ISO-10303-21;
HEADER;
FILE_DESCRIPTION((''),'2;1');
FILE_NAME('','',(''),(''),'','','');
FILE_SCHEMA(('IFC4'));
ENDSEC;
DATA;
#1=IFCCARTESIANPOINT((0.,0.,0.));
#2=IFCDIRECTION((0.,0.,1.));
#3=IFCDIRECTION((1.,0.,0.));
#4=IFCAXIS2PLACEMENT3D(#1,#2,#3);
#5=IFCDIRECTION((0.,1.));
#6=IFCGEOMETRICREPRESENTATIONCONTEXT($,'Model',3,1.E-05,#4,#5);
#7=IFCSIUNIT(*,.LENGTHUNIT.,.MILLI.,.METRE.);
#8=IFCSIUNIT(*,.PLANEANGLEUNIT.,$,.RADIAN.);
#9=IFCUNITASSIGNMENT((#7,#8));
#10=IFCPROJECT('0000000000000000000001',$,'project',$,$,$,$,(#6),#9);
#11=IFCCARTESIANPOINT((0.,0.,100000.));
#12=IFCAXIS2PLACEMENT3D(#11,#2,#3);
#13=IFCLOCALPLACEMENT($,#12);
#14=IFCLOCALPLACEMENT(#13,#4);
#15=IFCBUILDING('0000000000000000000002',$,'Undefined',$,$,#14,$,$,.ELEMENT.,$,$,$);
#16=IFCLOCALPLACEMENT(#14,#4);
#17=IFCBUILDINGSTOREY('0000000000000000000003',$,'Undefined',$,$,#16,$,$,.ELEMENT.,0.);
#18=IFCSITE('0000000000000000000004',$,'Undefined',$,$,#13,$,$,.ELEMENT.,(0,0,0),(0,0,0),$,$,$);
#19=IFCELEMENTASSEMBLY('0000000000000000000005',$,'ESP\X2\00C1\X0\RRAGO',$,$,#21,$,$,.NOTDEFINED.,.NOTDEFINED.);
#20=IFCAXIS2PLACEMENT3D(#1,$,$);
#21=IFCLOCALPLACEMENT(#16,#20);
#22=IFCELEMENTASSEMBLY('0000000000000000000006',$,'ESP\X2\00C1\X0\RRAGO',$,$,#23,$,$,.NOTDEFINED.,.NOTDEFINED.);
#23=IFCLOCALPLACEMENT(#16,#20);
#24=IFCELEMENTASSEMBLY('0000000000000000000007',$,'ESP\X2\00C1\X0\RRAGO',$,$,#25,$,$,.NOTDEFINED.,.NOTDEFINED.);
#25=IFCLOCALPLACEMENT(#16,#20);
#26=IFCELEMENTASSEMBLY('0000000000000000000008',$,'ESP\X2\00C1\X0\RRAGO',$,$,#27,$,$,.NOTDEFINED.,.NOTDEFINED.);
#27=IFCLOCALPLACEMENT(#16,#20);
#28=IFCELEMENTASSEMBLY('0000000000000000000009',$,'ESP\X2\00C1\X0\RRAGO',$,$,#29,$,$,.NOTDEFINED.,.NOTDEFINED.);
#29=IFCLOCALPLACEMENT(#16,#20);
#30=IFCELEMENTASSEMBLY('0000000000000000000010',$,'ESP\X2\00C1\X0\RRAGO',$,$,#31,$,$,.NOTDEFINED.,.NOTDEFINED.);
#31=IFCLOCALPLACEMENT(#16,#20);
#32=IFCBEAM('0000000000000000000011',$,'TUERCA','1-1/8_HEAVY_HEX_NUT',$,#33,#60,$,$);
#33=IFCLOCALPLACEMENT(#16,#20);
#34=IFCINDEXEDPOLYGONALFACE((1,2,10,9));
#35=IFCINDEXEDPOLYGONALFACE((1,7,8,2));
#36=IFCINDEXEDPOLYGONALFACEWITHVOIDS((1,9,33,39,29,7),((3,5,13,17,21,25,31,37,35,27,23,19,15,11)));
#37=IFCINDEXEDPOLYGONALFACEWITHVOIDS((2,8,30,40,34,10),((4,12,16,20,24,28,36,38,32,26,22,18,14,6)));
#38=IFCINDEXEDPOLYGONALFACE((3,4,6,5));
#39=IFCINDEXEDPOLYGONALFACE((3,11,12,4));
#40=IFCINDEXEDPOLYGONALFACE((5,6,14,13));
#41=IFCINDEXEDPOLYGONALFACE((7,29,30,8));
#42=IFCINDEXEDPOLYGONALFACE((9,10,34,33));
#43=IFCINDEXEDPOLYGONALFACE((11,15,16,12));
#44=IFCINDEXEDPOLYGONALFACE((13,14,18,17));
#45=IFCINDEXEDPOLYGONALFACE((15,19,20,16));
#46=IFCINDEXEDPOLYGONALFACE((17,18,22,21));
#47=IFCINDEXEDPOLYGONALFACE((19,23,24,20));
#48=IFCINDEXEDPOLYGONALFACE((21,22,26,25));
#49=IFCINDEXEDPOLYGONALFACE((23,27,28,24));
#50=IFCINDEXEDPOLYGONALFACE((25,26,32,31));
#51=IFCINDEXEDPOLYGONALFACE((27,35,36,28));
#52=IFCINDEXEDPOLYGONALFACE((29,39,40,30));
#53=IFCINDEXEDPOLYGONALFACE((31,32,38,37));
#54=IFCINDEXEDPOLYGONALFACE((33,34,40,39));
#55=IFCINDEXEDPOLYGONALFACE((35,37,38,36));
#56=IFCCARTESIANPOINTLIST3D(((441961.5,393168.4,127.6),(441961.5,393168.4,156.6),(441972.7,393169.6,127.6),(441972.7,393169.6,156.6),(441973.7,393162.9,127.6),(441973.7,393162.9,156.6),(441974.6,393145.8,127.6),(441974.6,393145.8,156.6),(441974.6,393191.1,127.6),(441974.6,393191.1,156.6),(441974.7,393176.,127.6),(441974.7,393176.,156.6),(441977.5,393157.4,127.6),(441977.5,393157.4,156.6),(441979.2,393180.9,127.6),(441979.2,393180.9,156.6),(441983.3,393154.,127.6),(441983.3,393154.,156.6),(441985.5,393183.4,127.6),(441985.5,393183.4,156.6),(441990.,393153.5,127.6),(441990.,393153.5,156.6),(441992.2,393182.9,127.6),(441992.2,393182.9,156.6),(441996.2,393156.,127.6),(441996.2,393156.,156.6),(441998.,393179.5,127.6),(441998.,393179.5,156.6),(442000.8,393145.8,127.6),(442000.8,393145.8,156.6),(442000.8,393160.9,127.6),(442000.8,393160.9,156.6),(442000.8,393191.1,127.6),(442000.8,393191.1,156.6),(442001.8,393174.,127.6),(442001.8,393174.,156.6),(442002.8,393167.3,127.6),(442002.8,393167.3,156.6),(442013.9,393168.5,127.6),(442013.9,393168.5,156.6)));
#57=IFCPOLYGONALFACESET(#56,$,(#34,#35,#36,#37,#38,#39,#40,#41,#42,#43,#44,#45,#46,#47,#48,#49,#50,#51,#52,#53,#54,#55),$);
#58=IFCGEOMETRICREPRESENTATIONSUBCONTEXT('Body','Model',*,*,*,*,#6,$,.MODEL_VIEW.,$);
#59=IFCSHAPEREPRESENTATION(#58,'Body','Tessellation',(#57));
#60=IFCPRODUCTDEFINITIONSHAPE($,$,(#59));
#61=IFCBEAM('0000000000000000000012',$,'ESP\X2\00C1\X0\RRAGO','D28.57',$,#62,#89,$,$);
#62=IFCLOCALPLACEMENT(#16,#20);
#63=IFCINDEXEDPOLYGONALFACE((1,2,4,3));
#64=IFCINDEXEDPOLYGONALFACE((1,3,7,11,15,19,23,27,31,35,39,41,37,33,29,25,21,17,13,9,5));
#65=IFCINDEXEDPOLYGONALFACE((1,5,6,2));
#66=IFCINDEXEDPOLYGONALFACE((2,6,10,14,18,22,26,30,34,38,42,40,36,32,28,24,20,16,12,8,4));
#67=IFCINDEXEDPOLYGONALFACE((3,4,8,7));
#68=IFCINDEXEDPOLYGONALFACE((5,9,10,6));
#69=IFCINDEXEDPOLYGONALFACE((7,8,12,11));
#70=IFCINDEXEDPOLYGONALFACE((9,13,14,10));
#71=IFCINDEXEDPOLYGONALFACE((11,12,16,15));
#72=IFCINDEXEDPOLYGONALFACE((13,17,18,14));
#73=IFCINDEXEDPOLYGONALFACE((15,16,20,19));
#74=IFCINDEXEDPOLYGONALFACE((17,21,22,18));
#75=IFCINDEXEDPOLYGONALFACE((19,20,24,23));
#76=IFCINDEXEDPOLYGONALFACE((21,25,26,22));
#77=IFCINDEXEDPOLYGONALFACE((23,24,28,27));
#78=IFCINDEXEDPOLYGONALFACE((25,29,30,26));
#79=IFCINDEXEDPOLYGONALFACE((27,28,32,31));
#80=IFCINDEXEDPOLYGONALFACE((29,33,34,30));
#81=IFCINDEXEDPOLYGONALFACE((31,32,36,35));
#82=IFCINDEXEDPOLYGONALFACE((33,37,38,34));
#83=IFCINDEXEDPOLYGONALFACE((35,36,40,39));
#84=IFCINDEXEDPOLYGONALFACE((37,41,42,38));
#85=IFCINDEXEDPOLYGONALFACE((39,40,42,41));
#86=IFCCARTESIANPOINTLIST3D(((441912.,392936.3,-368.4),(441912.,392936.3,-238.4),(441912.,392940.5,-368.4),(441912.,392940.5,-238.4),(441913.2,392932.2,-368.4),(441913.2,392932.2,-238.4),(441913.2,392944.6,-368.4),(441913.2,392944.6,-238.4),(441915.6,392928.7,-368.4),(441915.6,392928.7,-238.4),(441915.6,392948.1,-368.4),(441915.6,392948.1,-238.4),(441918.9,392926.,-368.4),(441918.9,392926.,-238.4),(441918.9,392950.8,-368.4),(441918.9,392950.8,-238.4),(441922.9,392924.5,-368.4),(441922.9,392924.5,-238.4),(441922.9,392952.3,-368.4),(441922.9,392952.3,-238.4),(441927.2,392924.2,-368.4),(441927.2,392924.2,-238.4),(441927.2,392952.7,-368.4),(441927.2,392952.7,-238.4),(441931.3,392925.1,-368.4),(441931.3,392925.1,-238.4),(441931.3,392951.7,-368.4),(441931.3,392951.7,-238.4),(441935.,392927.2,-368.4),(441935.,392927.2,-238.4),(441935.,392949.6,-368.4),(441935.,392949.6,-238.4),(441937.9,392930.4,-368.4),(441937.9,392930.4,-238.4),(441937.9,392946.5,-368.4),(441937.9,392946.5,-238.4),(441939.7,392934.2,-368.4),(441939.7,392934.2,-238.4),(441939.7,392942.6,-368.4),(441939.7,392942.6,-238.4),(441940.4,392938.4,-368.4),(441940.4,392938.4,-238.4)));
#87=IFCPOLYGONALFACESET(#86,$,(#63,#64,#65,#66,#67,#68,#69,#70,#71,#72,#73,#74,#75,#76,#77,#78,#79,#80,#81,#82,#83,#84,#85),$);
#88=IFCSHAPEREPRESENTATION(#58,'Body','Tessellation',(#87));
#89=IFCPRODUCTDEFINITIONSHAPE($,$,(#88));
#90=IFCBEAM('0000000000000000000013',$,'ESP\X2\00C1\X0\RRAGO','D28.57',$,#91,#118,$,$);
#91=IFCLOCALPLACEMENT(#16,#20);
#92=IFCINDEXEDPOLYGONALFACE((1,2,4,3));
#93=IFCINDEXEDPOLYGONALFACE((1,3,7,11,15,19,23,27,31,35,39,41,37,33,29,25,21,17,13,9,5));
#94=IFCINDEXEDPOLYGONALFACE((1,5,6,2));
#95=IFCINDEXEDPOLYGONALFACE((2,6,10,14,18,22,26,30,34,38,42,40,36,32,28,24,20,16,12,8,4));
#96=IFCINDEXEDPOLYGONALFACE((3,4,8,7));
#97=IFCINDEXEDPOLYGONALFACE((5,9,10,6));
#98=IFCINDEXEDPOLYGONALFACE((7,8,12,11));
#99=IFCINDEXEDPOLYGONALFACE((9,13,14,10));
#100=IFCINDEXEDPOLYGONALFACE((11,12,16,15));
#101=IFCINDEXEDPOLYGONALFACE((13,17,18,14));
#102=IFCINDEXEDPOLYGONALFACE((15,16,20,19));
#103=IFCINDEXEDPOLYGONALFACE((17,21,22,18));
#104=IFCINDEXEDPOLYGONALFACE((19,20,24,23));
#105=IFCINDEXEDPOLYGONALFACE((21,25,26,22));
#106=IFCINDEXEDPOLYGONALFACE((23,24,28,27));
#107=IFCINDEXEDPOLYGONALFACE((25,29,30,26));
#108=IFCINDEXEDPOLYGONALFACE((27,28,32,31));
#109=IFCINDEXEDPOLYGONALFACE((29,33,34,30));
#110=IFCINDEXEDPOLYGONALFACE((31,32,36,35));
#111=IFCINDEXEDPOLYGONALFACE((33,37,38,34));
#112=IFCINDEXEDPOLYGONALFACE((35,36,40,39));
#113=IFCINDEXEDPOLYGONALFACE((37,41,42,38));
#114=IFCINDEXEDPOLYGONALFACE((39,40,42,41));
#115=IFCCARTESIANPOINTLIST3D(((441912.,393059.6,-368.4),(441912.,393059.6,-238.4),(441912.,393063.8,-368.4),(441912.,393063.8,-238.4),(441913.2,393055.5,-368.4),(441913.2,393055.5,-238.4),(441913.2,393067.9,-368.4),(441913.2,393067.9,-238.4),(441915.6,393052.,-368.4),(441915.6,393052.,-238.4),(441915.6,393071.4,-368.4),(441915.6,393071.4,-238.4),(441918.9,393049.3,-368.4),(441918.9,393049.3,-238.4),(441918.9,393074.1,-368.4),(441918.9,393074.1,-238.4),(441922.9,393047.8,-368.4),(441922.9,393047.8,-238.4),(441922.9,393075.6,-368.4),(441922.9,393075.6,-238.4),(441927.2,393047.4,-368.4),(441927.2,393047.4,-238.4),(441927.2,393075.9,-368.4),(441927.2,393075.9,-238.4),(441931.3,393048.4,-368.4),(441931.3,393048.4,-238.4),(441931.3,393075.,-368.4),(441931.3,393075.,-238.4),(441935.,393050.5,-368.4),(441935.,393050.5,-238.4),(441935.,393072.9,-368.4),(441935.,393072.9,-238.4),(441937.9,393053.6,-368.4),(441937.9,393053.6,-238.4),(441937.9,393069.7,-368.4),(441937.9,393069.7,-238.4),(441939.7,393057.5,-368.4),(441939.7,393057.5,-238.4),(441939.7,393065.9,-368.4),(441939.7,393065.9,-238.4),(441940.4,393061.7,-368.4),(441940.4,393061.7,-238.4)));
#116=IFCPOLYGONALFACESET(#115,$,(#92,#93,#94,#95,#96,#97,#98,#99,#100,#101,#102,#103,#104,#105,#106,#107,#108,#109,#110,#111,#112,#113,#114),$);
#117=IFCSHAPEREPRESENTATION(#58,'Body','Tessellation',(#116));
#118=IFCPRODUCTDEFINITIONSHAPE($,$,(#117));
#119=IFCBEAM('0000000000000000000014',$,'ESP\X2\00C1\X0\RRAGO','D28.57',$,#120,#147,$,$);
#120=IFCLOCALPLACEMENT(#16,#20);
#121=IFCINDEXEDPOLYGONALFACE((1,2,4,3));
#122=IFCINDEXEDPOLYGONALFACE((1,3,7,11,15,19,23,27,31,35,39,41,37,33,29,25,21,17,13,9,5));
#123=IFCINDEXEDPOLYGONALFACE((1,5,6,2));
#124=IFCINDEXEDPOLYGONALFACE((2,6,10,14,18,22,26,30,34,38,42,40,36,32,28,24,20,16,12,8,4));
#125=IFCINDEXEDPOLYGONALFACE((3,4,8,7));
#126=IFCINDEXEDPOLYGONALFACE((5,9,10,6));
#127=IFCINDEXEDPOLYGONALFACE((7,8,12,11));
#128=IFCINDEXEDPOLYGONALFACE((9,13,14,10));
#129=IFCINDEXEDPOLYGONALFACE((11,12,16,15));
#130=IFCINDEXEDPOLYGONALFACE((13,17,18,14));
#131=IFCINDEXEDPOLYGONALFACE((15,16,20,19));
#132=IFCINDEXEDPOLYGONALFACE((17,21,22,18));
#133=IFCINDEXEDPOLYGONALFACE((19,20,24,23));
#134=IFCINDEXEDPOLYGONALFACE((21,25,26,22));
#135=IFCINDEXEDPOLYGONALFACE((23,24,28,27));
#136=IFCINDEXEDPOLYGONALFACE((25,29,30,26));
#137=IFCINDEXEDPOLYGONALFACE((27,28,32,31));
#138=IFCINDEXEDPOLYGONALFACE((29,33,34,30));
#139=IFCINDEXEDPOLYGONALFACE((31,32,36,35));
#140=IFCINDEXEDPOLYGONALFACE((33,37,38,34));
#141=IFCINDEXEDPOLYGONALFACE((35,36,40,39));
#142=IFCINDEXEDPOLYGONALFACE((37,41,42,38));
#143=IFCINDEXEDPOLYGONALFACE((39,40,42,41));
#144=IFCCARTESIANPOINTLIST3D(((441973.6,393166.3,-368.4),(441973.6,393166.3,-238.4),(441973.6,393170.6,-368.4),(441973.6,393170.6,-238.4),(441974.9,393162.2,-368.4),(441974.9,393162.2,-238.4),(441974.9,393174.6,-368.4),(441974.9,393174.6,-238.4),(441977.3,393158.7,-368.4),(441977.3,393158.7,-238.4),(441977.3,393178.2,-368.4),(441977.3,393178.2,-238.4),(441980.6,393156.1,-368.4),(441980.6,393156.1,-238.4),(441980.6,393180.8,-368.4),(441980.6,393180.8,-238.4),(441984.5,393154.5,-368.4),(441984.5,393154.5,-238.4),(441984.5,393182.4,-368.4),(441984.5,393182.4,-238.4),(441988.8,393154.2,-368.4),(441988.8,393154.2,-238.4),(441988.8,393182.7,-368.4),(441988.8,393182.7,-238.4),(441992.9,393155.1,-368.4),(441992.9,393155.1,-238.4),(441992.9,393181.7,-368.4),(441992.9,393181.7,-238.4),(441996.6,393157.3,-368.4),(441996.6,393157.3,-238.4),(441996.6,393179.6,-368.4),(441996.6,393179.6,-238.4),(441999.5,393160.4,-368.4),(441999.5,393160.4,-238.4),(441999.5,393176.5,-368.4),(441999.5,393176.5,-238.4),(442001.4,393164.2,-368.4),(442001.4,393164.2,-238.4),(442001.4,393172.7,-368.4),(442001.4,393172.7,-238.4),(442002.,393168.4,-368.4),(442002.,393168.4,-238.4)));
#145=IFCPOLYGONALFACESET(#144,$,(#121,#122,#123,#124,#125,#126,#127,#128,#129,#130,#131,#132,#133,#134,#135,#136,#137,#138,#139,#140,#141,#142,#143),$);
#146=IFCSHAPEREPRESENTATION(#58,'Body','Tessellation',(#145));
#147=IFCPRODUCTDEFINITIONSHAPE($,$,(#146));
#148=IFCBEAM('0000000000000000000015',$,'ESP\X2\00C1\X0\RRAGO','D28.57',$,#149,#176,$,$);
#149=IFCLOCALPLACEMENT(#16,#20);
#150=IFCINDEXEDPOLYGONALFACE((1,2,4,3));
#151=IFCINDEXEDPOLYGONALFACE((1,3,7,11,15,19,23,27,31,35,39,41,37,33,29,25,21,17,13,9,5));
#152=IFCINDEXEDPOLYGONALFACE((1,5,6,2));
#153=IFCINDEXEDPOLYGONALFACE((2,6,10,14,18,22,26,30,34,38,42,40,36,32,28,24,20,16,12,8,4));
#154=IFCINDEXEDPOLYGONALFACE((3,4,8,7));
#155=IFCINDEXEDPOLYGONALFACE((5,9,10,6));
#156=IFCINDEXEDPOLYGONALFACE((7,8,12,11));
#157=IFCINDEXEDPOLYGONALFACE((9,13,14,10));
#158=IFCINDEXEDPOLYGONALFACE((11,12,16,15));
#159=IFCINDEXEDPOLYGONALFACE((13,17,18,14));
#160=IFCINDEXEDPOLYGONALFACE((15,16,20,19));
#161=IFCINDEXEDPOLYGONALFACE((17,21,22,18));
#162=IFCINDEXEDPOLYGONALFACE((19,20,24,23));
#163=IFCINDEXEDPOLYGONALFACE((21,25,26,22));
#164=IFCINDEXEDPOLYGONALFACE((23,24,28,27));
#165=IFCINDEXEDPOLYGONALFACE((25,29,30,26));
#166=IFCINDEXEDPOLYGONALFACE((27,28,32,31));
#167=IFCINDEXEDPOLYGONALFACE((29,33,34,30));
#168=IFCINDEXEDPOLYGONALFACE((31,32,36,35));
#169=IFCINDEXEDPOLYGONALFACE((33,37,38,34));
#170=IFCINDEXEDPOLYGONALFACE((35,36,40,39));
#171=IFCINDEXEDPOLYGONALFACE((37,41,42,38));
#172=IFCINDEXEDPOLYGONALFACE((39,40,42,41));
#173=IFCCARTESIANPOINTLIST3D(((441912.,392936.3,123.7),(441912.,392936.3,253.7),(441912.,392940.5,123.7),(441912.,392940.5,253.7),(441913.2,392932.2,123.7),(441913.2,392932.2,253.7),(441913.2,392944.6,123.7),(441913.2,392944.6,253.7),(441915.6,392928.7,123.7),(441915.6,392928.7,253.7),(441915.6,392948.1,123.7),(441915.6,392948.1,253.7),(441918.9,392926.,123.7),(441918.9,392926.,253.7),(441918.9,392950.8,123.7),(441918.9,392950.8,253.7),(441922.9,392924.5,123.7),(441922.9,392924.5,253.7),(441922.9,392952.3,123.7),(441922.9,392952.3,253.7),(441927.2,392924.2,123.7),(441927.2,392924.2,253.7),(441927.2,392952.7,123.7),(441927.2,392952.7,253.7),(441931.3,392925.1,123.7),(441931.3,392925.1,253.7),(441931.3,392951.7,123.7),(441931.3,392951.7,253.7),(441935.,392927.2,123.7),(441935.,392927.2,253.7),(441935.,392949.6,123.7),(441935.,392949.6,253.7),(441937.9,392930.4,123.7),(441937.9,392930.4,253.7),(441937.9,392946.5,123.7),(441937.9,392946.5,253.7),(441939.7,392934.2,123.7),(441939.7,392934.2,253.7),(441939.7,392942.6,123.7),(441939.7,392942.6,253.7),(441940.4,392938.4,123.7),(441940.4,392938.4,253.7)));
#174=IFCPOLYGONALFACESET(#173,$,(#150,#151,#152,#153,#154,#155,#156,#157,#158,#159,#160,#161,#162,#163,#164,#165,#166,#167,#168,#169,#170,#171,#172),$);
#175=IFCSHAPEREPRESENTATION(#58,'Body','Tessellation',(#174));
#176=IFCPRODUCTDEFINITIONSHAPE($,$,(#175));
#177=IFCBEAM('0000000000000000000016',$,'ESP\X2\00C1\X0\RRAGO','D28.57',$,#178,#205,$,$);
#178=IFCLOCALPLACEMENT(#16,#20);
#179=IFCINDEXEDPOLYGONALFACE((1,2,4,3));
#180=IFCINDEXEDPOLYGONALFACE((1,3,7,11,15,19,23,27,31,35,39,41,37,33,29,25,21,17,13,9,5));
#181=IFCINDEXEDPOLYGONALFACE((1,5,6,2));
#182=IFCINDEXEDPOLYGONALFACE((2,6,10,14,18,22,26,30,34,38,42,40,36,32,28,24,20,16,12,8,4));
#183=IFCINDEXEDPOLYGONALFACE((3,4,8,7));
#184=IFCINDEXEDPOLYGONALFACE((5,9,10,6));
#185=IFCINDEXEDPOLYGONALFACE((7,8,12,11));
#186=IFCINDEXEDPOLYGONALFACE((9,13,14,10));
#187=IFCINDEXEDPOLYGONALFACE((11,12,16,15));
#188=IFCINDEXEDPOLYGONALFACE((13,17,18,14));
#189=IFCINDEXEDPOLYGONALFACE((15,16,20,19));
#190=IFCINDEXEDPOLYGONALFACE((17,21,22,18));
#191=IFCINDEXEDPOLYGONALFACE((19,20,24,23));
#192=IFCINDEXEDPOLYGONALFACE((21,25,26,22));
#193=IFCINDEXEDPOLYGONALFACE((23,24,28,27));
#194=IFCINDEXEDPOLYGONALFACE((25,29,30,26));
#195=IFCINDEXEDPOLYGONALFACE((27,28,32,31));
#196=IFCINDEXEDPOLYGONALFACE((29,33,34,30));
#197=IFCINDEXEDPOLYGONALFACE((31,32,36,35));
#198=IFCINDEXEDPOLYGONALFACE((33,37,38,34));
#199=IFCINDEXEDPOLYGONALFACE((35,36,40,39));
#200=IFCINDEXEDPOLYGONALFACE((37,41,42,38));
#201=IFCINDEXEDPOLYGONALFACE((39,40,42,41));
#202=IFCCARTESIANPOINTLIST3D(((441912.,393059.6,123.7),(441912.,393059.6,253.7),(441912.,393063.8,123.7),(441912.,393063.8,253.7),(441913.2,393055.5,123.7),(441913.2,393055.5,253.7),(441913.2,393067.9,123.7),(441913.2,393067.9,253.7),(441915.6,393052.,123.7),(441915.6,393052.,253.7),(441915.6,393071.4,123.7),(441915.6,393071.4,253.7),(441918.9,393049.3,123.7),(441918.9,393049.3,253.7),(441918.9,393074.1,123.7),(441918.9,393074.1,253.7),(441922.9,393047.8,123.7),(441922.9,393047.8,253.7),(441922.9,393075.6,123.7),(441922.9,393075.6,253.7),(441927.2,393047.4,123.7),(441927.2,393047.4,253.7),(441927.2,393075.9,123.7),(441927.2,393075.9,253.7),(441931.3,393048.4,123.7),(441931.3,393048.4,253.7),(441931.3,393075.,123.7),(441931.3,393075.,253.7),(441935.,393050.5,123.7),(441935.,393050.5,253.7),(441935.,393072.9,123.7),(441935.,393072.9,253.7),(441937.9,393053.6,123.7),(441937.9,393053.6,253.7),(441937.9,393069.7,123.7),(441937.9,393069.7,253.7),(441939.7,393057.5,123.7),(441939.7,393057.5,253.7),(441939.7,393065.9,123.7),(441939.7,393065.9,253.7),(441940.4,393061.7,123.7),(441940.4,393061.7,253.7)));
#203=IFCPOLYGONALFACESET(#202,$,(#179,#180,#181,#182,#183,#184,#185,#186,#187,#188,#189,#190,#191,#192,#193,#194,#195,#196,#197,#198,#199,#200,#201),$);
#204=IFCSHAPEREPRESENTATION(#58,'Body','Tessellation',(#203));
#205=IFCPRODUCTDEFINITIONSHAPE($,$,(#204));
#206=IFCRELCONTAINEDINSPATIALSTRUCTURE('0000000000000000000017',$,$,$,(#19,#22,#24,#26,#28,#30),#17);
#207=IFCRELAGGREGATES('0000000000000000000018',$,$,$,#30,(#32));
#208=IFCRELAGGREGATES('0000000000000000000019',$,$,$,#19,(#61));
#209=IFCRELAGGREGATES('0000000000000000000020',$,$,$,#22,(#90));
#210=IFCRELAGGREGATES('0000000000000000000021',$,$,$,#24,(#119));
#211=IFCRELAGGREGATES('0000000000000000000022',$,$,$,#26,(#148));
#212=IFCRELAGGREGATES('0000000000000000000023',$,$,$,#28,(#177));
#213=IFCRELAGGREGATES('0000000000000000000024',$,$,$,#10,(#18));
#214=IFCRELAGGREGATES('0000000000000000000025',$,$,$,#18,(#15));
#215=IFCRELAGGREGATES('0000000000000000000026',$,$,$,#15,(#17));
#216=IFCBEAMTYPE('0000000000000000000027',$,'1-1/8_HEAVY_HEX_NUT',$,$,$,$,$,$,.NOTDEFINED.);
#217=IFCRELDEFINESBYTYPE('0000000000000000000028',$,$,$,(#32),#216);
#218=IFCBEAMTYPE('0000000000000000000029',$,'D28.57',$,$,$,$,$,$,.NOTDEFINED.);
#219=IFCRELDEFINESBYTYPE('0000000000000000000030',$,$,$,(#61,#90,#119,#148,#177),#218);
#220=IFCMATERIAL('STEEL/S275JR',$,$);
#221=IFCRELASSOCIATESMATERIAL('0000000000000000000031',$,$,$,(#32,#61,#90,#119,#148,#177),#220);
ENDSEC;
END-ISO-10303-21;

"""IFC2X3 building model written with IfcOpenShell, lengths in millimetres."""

from ifc_helpers import new_model, si_unit, direction, frame, origin_with_axes, origin_2d_with_axis, place, context, subcontext, project, spatial, polyline, circle, outline, extrude, material, type_object, element, aggregate, save


model = new_model("IFC2X3")

# Units and contexts
model_context = context("Model", 3, precision=1e-05, world=origin_with_axes(), true_north=direction((0.0, 1.0)))
body_context = subcontext(model_context, "Body", "Model", "MODEL_VIEW")
ifc_project = project(units=[si_unit("LENGTHUNIT", "METRE", prefix="MILLI"), si_unit("PLANEANGLEUNIT", "RADIAN")], contexts=[model_context])

# Site, building, storey
site_placement = place(None, frame((0.0, 0.0, 100000.0), z_axis=(0.0, 0.0, 1.0), x_axis=(1.0, 0.0, 0.0)))
site = spatial("IfcSite", under=ifc_project, at=site_placement, Name="Undefined", CompositionType="ELEMENT", RefLatitude=(0, 0, 0), RefLongitude=(0, 0, 0))
building_placement = place(site_placement, origin_with_axes())
building = spatial("IfcBuilding", under=site, at=building_placement, Name="Undefined", CompositionType="ELEMENT")
storey_placement = place(building_placement, origin_with_axes())
storey = spatial("IfcBuildingStorey", under=building, at=storey_placement, Name="Undefined", CompositionType="ELEMENT", Elevation=0.0)

# Element assemblies
assembly_1_placement = place(storey_placement, origin_with_axes())
assembly_1 = element("IfcElementAssembly", 1, at=assembly_1_placement, inside=storey, Name="ESPÁRRAGO", AssemblyPlace="NOTDEFINED", PredefinedType="NOTDEFINED")
ifc_material_1 = material(Name="STEEL/S275JR")
beam_type_1 = type_object("IfcBeamType", Name="1-1/8_HEAVY_HEX_NUT", PredefinedType="NOTDEFINED")
assembly_2_placement = place(storey_placement, origin_with_axes())
assembly_2 = element("IfcElementAssembly", 2, at=assembly_2_placement, inside=storey, Name="ESPÁRRAGO", AssemblyPlace="NOTDEFINED", PredefinedType="NOTDEFINED")
assembly_3_placement = place(storey_placement, origin_with_axes())
assembly_3 = element("IfcElementAssembly", 3, at=assembly_3_placement, inside=storey, Name="ESPÁRRAGO", AssemblyPlace="NOTDEFINED", PredefinedType="NOTDEFINED")

# Element assemblies
assembly_4_placement = place(storey_placement, origin_with_axes())
assembly_4 = element("IfcElementAssembly", 4, at=assembly_4_placement, inside=storey, Name="ESPÁRRAGO", AssemblyPlace="NOTDEFINED", PredefinedType="NOTDEFINED")
assembly_5_placement = place(storey_placement, origin_with_axes())
assembly_5 = element("IfcElementAssembly", 5, at=assembly_5_placement, inside=storey, Name="ESPÁRRAGO", AssemblyPlace="NOTDEFINED", PredefinedType="NOTDEFINED")

# Element assembly, beam
assembly_6_placement = place(storey_placement, origin_with_axes())
assembly_6 = element("IfcElementAssembly", 6, at=assembly_6_placement, inside=storey, Name="ESPÁRRAGO", AssemblyPlace="NOTDEFINED", PredefinedType="NOTDEFINED")
beam_1_placement = place(assembly_6_placement, frame((441987.7, 393168.4, 156.6), z_axis=(0.866025, -0.5, 0.0), x_axis=(0.0, 0.0, -1.0)))
beam_1 = element("IfcBeam", 7, at=beam_1_placement, type_object=beam_type_1, material=ifc_material_1, Name="TUERCA", Description="1-1/8_HEAVY_HEX_NUT", context=body_context, shape_type="SweptSolid", body=[
    extrude(outline(polyline([(-13.1, -22.7), (-26.2, 0.0), (-13.1, 22.7), (13.1, 22.7), (26.2, 0.0), (13.1, -22.7), (-13.1, -22.7)]), holes=[polyline([(6.5, 13.6), (0.0, 15.1), (-6.5, 13.6), (-11.8, 9.4), (-14.7, 3.4), (-14.7, -3.4), (-11.8, -9.4), (-6.5, -13.6), (0.0, -15.1), (6.5, -13.6), (11.8, -9.4), (14.7, -3.4), (14.7, 3.4), (11.8, 9.4), (6.5, 13.6)])]), frame((29.0, 0.0, 0.0), z_axis=(-1.0, 0.0, 0.0), x_axis=(0.0, -1.0, 0.0)), (0.0, 0.0, 1.0), 29.0),
])
aggregate(assembly_6, [beam_1])

# Beams
beam_type_2 = type_object("IfcBeamType", Name="D28.57", PredefinedType="NOTDEFINED")
beam_2_placement = place(assembly_1_placement, frame((441926.1, 392938.4, -238.4), z_axis=(0.866025, -0.5, 0.0), x_axis=(0.0, 0.0, -1.0)))
beam_2 = element("IfcBeam", 8, at=beam_2_placement, type_object=beam_type_2, material=ifc_material_1, Name="ESPÁRRAGO", Description="D28.57", context=body_context, shape_type="SweptSolid", body=[
    extrude(circle(Radius=14.3, at=origin_2d_with_axis()), frame((130.0, 0.0, 0.0), z_axis=(-1.0, 0.0, 0.0), x_axis=(0.0, -1.0, 0.0)), (0.0, 0.0, 1.0), 130.0),
])
aggregate(assembly_1, [beam_2])
beam_3_placement = place(assembly_2_placement, frame((441926.1, 393061.7, -238.4), z_axis=(0.866025, -0.5, 0.0), x_axis=(0.0, 0.0, -1.0)))
beam_3 = element("IfcBeam", 9, at=beam_3_placement, type_object=beam_type_2, material=ifc_material_1, Name="ESPÁRRAGO", Description="D28.57", context=body_context, shape_type="SweptSolid", body=[
    extrude(circle(Radius=14.3, at=origin_2d_with_axis()), frame((130.0, 0.0, 0.0), z_axis=(-1.0, 0.0, 0.0), x_axis=(0.0, -1.0, 0.0)), (0.0, 0.0, 1.0), 130.0),
])
aggregate(assembly_2, [beam_3])
beam_4_placement = place(assembly_3_placement, frame((441987.7, 393168.4, -238.4), z_axis=(0.866025, -0.5, 0.0), x_axis=(0.0, 0.0, -1.0)))
beam_4 = element("IfcBeam", 10, at=beam_4_placement, type_object=beam_type_2, material=ifc_material_1, Name="ESPÁRRAGO", Description="D28.57", context=body_context, shape_type="SweptSolid", body=[
    extrude(circle(Radius=14.3, at=origin_2d_with_axis()), frame((130.0, 0.0, 0.0), z_axis=(-1.0, 0.0, 0.0), x_axis=(0.0, -1.0, 0.0)), (0.0, 0.0, 1.0), 130.0),
])
aggregate(assembly_3, [beam_4])
beam_5_placement = place(assembly_4_placement, frame((441926.1, 392938.4, 253.7), z_axis=(0.866025, -0.5, 0.0), x_axis=(0.0, 0.0, -1.0)))
beam_5 = element("IfcBeam", 11, at=beam_5_placement, type_object=beam_type_2, material=ifc_material_1, Name="ESPÁRRAGO", Description="D28.57", context=body_context, shape_type="SweptSolid", body=[
    extrude(circle(Radius=14.3, at=origin_2d_with_axis()), frame((130.0, 0.0, 0.0), z_axis=(-1.0, 0.0, 0.0), x_axis=(0.0, -1.0, 0.0)), (0.0, 0.0, 1.0), 130.0),
])
aggregate(assembly_4, [beam_5])
beam_6_placement = place(assembly_5_placement, frame((441926.1, 393061.7, 253.7), z_axis=(0.866025, -0.5, 0.0), x_axis=(0.0, 0.0, -1.0)))
beam_6 = element("IfcBeam", 12, at=beam_6_placement, type_object=beam_type_2, material=ifc_material_1, Name="ESPÁRRAGO", Description="D28.57", context=body_context, shape_type="SweptSolid", body=[
    extrude(circle(Radius=14.3, at=origin_2d_with_axis()), frame((130.0, 0.0, 0.0), z_axis=(-1.0, 0.0, 0.0), x_axis=(0.0, -1.0, 0.0)), (0.0, 0.0, 1.0), 130.0),
])
aggregate(assembly_5, [beam_6])

save(model, "model.ifc")
